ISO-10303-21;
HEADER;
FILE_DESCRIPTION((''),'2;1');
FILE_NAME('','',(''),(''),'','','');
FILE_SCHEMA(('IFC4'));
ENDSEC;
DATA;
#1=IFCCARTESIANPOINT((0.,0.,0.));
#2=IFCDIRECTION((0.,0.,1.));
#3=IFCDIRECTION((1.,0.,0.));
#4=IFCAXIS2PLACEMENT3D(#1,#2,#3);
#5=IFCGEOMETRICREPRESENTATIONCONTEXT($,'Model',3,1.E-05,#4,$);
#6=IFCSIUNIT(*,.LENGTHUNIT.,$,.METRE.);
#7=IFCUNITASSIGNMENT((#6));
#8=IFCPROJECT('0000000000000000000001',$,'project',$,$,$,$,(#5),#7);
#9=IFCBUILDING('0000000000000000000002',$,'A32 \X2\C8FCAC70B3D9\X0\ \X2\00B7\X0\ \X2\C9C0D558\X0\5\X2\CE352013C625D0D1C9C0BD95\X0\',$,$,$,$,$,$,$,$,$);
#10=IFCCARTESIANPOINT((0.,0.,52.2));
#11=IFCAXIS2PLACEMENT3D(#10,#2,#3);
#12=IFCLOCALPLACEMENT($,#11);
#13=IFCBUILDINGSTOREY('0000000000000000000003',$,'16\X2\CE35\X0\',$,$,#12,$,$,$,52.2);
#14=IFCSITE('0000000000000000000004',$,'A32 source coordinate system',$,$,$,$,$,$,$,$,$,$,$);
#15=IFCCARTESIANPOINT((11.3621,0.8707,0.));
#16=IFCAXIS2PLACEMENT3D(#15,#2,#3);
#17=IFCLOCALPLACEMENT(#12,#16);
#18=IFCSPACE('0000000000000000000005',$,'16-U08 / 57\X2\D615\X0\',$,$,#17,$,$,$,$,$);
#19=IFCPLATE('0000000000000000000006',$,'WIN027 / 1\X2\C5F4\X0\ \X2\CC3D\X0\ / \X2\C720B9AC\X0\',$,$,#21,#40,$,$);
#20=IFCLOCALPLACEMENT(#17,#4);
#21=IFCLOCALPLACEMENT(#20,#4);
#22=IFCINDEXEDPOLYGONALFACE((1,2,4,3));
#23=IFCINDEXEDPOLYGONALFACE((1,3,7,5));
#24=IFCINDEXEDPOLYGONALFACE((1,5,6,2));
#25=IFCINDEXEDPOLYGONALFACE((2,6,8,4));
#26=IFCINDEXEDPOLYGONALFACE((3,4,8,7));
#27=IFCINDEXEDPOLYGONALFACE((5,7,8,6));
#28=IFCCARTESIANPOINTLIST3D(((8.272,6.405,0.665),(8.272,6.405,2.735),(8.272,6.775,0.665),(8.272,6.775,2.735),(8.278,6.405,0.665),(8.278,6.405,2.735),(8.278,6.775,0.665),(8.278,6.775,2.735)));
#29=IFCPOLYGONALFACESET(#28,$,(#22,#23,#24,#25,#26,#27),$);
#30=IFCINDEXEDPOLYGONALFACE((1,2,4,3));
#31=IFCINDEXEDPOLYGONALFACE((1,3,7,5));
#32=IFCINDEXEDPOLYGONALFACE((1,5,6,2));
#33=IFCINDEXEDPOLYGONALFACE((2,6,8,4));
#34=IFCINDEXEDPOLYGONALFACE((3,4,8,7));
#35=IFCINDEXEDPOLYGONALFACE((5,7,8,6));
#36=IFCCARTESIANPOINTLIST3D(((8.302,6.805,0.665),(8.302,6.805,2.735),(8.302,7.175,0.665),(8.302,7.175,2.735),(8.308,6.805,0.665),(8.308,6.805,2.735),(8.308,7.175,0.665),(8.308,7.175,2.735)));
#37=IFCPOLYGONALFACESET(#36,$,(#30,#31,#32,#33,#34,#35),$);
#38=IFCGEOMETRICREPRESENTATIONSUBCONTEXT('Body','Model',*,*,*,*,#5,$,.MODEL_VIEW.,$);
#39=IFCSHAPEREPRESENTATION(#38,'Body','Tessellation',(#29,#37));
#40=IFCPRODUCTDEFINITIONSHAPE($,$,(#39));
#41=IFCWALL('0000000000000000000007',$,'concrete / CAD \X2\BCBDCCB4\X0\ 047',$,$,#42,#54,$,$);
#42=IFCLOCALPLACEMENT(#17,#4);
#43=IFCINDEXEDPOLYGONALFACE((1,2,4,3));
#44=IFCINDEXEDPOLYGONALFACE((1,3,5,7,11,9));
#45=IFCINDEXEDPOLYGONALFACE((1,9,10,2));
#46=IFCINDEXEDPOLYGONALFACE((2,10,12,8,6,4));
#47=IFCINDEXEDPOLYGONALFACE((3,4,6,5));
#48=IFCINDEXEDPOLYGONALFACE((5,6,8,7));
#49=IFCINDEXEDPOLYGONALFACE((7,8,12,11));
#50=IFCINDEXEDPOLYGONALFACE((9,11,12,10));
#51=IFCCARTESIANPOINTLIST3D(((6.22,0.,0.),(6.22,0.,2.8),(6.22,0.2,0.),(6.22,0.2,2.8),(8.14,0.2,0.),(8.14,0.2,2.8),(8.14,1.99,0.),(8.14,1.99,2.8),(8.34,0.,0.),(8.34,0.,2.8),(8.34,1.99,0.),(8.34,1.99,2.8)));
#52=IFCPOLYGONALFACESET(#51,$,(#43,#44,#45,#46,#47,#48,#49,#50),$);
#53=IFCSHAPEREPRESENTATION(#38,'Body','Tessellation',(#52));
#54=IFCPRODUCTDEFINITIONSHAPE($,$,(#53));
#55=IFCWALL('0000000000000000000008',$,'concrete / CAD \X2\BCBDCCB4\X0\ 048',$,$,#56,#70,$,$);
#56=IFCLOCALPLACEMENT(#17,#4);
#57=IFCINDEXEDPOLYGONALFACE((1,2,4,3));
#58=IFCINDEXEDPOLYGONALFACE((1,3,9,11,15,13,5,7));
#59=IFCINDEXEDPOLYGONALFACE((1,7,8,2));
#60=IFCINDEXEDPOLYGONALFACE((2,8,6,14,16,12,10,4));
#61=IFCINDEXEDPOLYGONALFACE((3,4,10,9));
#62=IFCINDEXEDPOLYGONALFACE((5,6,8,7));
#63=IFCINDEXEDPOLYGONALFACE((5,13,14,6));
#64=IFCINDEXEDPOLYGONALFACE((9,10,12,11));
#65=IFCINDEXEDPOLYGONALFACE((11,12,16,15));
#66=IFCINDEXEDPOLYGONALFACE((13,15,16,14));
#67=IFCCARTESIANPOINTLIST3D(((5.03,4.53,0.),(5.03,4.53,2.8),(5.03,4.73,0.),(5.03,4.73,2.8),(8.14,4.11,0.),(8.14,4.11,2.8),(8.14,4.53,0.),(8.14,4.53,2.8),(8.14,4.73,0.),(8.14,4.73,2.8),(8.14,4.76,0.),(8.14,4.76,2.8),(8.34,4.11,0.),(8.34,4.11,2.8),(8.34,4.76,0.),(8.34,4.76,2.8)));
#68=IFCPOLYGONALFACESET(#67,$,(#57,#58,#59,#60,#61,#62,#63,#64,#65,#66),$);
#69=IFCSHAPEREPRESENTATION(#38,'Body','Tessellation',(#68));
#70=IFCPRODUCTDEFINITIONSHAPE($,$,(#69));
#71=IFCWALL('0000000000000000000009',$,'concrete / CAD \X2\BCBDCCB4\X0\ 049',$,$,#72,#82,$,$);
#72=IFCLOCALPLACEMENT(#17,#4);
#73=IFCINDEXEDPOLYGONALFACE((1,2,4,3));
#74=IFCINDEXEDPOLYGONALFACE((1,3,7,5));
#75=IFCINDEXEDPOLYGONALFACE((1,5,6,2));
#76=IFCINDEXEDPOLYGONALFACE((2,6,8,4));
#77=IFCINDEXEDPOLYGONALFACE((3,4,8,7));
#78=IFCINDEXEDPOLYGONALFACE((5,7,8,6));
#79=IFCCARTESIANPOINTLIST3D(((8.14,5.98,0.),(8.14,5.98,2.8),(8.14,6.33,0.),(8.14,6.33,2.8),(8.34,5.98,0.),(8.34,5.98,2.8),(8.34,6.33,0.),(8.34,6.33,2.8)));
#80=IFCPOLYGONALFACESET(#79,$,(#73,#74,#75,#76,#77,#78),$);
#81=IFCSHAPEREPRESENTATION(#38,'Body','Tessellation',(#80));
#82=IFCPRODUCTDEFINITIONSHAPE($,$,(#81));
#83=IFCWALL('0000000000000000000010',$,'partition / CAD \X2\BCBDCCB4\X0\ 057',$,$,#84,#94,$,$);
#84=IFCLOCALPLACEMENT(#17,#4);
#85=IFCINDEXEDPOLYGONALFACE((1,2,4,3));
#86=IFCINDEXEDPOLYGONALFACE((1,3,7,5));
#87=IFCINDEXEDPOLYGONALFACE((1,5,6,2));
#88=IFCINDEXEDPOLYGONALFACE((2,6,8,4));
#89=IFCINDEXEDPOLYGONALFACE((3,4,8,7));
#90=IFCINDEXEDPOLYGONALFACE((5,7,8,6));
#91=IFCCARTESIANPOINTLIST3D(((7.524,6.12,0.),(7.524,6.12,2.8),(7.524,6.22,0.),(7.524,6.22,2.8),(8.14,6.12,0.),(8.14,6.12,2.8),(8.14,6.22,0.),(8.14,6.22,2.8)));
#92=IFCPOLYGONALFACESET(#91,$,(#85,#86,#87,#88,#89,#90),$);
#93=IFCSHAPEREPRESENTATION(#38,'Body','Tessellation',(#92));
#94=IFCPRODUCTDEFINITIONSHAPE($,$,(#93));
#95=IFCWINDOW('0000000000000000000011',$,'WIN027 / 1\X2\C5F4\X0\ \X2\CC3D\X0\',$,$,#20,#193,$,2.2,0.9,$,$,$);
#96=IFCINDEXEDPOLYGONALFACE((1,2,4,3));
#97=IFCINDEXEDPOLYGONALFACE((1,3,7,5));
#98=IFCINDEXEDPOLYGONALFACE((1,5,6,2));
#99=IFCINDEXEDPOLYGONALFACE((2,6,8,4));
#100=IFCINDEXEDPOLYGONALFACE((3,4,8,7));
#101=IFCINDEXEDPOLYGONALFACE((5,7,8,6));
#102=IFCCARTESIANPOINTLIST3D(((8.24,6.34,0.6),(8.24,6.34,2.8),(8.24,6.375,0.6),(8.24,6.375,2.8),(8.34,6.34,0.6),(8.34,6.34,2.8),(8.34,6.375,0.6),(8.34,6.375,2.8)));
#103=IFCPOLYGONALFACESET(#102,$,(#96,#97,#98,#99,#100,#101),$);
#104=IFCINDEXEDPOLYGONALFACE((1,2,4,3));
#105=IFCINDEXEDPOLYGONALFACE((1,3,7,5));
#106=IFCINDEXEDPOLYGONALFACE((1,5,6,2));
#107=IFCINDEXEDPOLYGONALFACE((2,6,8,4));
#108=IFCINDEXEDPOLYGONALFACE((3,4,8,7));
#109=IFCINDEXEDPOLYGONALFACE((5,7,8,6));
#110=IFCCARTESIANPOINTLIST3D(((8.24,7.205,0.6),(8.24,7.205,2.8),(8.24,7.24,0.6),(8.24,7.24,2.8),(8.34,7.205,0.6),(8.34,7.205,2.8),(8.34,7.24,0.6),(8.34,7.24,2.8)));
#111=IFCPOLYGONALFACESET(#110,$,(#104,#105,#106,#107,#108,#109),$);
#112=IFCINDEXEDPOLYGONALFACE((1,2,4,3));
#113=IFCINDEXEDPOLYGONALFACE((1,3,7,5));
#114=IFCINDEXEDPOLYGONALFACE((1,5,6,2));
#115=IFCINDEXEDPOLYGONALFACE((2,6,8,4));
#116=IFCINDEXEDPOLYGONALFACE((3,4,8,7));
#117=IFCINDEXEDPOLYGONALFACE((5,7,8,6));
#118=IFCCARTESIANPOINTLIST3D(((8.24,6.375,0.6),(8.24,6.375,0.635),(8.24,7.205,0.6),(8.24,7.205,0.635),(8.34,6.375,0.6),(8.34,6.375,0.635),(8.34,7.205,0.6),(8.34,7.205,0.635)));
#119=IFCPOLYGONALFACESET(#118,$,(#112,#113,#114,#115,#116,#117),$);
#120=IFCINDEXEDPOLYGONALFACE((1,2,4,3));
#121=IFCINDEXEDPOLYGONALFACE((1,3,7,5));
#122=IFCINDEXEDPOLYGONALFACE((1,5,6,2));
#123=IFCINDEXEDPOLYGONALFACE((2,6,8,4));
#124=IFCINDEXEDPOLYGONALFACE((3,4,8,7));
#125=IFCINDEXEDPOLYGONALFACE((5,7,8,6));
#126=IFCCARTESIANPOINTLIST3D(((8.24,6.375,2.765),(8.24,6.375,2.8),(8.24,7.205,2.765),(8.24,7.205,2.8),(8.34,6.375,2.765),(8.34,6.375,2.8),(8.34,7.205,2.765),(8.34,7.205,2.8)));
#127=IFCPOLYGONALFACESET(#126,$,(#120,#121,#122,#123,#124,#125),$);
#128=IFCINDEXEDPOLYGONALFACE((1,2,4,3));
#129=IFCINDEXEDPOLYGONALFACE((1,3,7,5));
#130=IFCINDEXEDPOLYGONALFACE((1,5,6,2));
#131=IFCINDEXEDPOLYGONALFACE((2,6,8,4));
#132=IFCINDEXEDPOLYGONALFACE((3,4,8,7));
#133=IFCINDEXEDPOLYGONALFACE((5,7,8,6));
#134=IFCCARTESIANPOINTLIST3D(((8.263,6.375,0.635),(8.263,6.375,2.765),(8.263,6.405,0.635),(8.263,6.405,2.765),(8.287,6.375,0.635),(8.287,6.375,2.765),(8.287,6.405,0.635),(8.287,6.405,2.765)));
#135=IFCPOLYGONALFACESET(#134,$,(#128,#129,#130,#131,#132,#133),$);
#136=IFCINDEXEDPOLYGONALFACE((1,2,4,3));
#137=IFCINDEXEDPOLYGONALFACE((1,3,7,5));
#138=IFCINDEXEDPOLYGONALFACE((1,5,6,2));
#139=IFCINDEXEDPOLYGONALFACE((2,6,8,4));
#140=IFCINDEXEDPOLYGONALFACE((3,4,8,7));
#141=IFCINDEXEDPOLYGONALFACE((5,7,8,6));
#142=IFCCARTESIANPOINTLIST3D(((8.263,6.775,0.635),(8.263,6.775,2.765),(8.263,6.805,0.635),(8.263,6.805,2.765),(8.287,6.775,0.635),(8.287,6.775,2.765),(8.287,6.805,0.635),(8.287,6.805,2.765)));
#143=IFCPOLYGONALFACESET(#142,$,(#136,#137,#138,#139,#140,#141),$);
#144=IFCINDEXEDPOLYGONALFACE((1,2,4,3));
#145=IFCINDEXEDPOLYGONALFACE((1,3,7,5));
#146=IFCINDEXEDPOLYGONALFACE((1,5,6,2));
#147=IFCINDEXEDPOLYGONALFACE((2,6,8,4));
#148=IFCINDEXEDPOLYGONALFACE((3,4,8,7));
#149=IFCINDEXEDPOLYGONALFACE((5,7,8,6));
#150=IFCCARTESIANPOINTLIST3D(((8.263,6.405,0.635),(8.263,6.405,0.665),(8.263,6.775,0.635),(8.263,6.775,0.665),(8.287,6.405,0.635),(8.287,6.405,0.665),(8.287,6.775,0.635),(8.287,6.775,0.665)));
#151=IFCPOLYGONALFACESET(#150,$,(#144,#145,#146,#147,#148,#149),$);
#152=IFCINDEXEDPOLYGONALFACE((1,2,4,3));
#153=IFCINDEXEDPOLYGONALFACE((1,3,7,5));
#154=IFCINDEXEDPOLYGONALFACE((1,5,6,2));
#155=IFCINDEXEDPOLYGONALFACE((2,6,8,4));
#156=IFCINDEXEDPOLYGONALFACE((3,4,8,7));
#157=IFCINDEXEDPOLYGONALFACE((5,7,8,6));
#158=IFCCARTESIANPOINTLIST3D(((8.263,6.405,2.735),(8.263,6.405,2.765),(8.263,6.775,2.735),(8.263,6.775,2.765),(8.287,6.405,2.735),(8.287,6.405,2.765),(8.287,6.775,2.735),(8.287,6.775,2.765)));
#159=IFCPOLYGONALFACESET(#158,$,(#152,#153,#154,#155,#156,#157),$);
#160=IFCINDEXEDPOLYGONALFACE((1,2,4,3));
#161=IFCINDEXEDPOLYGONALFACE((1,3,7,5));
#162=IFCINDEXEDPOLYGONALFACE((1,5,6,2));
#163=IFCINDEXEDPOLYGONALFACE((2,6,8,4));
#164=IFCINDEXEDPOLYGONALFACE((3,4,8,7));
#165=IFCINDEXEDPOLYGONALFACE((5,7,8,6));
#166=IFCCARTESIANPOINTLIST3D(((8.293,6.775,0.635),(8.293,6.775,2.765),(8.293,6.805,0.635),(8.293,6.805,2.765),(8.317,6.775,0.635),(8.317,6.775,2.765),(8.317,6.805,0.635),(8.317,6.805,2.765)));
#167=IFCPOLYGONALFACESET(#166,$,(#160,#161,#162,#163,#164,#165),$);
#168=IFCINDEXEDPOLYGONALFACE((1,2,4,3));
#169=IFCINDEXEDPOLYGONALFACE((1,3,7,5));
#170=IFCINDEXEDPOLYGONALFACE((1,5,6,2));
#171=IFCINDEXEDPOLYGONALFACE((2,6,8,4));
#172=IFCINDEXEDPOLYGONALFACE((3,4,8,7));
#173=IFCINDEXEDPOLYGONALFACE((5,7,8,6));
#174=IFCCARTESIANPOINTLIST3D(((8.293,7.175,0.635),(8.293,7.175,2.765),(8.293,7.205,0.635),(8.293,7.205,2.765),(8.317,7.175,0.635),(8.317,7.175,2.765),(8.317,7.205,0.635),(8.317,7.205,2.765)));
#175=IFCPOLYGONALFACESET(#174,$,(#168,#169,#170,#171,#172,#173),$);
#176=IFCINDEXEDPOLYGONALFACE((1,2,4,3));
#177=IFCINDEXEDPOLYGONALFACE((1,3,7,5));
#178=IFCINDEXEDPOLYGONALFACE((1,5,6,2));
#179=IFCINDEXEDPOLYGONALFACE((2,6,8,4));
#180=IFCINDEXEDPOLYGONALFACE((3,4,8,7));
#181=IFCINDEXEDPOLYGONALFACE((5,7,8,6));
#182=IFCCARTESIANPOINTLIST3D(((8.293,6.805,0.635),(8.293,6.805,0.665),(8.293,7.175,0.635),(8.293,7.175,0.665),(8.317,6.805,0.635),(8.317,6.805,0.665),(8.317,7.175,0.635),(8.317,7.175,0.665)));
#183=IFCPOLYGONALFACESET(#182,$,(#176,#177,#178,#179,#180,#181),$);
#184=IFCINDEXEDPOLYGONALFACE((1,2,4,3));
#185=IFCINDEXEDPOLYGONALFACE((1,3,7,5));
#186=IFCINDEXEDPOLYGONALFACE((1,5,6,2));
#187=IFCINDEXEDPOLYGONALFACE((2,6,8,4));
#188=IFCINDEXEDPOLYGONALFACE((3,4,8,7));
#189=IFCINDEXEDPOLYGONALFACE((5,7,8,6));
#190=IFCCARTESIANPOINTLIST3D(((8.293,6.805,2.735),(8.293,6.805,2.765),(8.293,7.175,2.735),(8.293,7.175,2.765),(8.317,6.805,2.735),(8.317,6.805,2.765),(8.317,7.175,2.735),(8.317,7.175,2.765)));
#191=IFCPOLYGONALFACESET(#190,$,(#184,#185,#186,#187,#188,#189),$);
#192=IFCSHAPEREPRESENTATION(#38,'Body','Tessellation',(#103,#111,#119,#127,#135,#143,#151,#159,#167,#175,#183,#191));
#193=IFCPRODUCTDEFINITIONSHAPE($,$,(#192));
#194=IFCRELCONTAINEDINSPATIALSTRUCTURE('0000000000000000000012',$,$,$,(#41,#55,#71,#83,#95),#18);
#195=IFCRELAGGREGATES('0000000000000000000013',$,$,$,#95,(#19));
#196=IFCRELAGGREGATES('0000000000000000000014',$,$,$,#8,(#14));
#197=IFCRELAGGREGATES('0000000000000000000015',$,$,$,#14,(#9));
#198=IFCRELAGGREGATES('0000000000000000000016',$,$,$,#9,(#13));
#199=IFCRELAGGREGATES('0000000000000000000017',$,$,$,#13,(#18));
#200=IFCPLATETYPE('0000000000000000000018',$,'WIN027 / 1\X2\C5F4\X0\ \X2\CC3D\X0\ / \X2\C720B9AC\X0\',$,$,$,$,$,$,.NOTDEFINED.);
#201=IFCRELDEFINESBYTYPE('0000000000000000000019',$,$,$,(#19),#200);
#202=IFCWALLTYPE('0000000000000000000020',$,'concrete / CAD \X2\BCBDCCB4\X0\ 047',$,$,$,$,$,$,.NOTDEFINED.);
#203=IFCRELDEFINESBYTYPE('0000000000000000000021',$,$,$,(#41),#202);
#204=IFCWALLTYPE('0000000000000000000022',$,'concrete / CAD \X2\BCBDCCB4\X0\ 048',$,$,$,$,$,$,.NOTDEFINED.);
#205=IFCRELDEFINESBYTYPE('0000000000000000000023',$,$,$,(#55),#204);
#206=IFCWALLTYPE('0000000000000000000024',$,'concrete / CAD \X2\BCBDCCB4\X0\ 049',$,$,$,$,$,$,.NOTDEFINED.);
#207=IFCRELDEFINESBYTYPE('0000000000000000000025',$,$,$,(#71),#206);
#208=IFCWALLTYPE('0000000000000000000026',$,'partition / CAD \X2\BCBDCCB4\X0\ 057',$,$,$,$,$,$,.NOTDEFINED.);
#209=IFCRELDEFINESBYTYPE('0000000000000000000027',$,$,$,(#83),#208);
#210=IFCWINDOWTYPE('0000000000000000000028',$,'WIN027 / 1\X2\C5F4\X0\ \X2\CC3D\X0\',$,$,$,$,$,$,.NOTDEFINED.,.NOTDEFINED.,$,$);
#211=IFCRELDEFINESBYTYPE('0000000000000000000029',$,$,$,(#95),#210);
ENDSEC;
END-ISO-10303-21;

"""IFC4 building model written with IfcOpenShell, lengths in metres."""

from ifc_helpers import new_model, si_unit, frame, origin, origin_with_axes, place, context, subcontext, project, spatial, polyline, outline, extrude, source, transform, mapped, type_object, type_shapes, element, aggregate, save


model = new_model("IFC4")

# Units and contexts
model_context = context("Model", 3, precision=1e-05, world=origin_with_axes())
body_context = subcontext(model_context, "Body", "Model", "MODEL_VIEW")
ifc_project = project(units=[si_unit("LENGTHUNIT", "METRE")], contexts=[model_context])

# Plate
storey_placement = place(None, frame((0.0, 0.0, 52.2), z_axis=(0.0, 0.0, 1.0), x_axis=(1.0, 0.0, 0.0)))
space_placement = place(storey_placement, frame((11.3621, 0.8707, 0.0), z_axis=(0.0, 0.0, 1.0), x_axis=(1.0, 0.0, 0.0)))
plate_type_1 = type_object("IfcPlateType", Name="WIN027 / 1열 창 / 유리", PredefinedType="NOTDEFINED")
shared_shape_1 = source(origin(), body_context, "Body", "SweptSolid", [
    extrude(outline(polyline([(8.272, 6.405), (8.272, 6.775), (8.278, 6.775), (8.278, 6.405), (8.272, 6.405)])), frame((0.0, 0.0, 0.665)), (0.0, 0.0, 1.0), 2.07),
    extrude(outline(polyline([(8.302, 6.805), (8.302, 7.175), (8.308, 7.175), (8.308, 6.805), (8.302, 6.805)])), frame((0.0, 0.0, 0.665)), (0.0, 0.0, 1.0), 2.07),
])
type_shapes(plate_type_1, [shared_shape_1])
window_1_placement = place(space_placement, origin_with_axes())
plate_1_placement = place(window_1_placement, origin_with_axes())
plate_1 = element("IfcPlate", 1, at=plate_1_placement, type_object=plate_type_1, Name="WIN027 / 1열 창 / 유리", context=body_context, shape_type="MappedRepresentation", body=[
    mapped(shared_shape_1, transform((0.0, 0.0, 0.0), scale=1.0)),
])

# Site, building, storey, space
site = spatial("IfcSite", under=ifc_project, Name="A32 source coordinate system")
building = spatial("IfcBuilding", under=site, Name="A32 주거동 · 지하5층–옥탑지붕")
storey = spatial("IfcBuildingStorey", under=building, at=storey_placement, Name="16층", Elevation=52.2)
space = spatial("IfcSpace", under=storey, at=space_placement, Name="16-U08 / 57형")

# Walls
wall_type_1 = type_object("IfcWallType", Name="concrete / CAD 벽체 047", PredefinedType="NOTDEFINED")
shared_shape_2 = source(origin(), body_context, "Body", "SweptSolid", [
    extrude(outline(polyline([(8.14, 1.99), (8.34, 1.99), (8.34, 0.0), (6.22, 0.0), (6.22, 0.2), (8.14, 0.2), (8.14, 1.99)])), origin(), (0.0, 0.0, 1.0), 2.8),
])
type_shapes(wall_type_1, [shared_shape_2])
wall_1_placement = place(space_placement, origin_with_axes())
element("IfcWall", 2, at=wall_1_placement, inside=space, type_object=wall_type_1, Name="concrete / CAD 벽체 047", context=body_context, shape_type="MappedRepresentation", body=[
    mapped(shared_shape_2, transform((0.0, 0.0, 0.0), scale=1.0)),
])
wall_type_2 = type_object("IfcWallType", Name="concrete / CAD 벽체 048", PredefinedType="NOTDEFINED")
shared_shape_3 = source(origin(), body_context, "Body", "SweptSolid", [
    extrude(outline(polyline([(8.14, 4.53), (5.03, 4.53), (5.03, 4.73), (8.14, 4.73), (8.14, 4.76), (8.34, 4.76), (8.34, 4.11), (8.14, 4.11), (8.14, 4.53)])), origin(), (0.0, 0.0, 1.0), 2.8),
])
type_shapes(wall_type_2, [shared_shape_3])
wall_2_placement = place(space_placement, origin_with_axes())
element("IfcWall", 3, at=wall_2_placement, inside=space, type_object=wall_type_2, Name="concrete / CAD 벽체 048", context=body_context, shape_type="MappedRepresentation", body=[
    mapped(shared_shape_3, transform((0.0, 0.0, 0.0), scale=1.0)),
])
wall_type_3 = type_object("IfcWallType", Name="concrete / CAD 벽체 049", PredefinedType="NOTDEFINED")
shared_shape_4 = source(origin(), body_context, "Body", "SweptSolid", [
    extrude(outline(polyline([(8.34, 6.33), (8.34, 5.98), (8.14, 5.98), (8.14, 6.33), (8.34, 6.33)])), origin(), (0.0, 0.0, 1.0), 2.8),
])
type_shapes(wall_type_3, [shared_shape_4])
wall_3_placement = place(space_placement, origin_with_axes())
element("IfcWall", 4, at=wall_3_placement, inside=space, type_object=wall_type_3, Name="concrete / CAD 벽체 049", context=body_context, shape_type="MappedRepresentation", body=[
    mapped(shared_shape_4, transform((0.0, 0.0, 0.0), scale=1.0)),
])
wall_type_4 = type_object("IfcWallType", Name="partition / CAD 벽체 057", PredefinedType="NOTDEFINED")
shared_shape_5 = source(origin(), body_context, "Body", "SweptSolid", [
    extrude(outline(polyline([(7.524, 6.22), (8.14, 6.22), (8.14, 6.12), (7.524, 6.12), (7.524, 6.22)])), origin(), (0.0, 0.0, 1.0), 2.8),
])
type_shapes(wall_type_4, [shared_shape_5])
wall_4_placement = place(space_placement, origin_with_axes())
element("IfcWall", 5, at=wall_4_placement, inside=space, type_object=wall_type_4, Name="partition / CAD 벽체 057", context=body_context, shape_type="MappedRepresentation", body=[
    mapped(shared_shape_5, transform((0.0, 0.0, 0.0), scale=1.0)),
])

# Window
window_type_1 = type_object("IfcWindowType", Name="WIN027 / 1열 창", PartitioningType="NOTDEFINED", PredefinedType="NOTDEFINED")
shared_shape_6 = source(origin(), body_context, "Body", "SweptSolid", [
    extrude(outline(polyline([(8.24, 6.34), (8.24, 6.375), (8.34, 6.375), (8.34, 6.34), (8.24, 6.34)])), frame((0.0, 0.0, 0.6)), (0.0, 0.0, 1.0), 2.2),
    extrude(outline(polyline([(8.24, 7.205), (8.24, 7.24), (8.34, 7.24), (8.34, 7.205), (8.24, 7.205)])), frame((0.0, 0.0, 0.6)), (0.0, 0.0, 1.0), 2.2),
    extrude(outline(polyline([(8.24, 6.375), (8.24, 7.205), (8.34, 7.205), (8.34, 6.375), (8.24, 6.375)])), frame((0.0, 0.0, 0.6)), (0.0, 0.0, 1.0), 0.035),
    extrude(outline(polyline([(8.24, 6.375), (8.24, 7.205), (8.34, 7.205), (8.34, 6.375), (8.24, 6.375)])), frame((0.0, 0.0, 2.765)), (0.0, 0.0, 1.0), 0.035),
    extrude(outline(polyline([(8.263, 6.375), (8.263, 6.405), (8.287, 6.405), (8.287, 6.375), (8.263, 6.375)])), frame((0.0, 0.0, 0.635)), (0.0, 0.0, 1.0), 2.13),
    extrude(outline(polyline([(8.263, 6.775), (8.263, 6.805), (8.287, 6.805), (8.287, 6.775), (8.263, 6.775)])), frame((0.0, 0.0, 0.635)), (0.0, 0.0, 1.0), 2.13),
    extrude(outline(polyline([(8.263, 6.405), (8.263, 6.775), (8.287, 6.775), (8.287, 6.405), (8.263, 6.405)])), frame((0.0, 0.0, 0.635)), (0.0, 0.0, 1.0), 0.03),
    extrude(outline(polyline([(8.263, 6.405), (8.263, 6.775), (8.287, 6.775), (8.287, 6.405), (8.263, 6.405)])), frame((0.0, 0.0, 2.735)), (0.0, 0.0, 1.0), 0.03),
    extrude(outline(polyline([(8.293, 6.775), (8.293, 6.805), (8.317, 6.805), (8.317, 6.775), (8.293, 6.775)])), frame((0.0, 0.0, 0.635)), (0.0, 0.0, 1.0), 2.13),
    extrude(outline(polyline([(8.293, 7.175), (8.293, 7.205), (8.317, 7.205), (8.317, 7.175), (8.293, 7.175)])), frame((0.0, 0.0, 0.635)), (0.0, 0.0, 1.0), 2.13),
    extrude(outline(polyline([(8.293, 6.805), (8.293, 7.175), (8.317, 7.175), (8.317, 6.805), (8.293, 6.805)])), frame((0.0, 0.0, 0.635)), (0.0, 0.0, 1.0), 0.03),
    extrude(outline(polyline([(8.293, 6.805), (8.293, 7.175), (8.317, 7.175), (8.317, 6.805), (8.293, 6.805)])), frame((0.0, 0.0, 2.735)), (0.0, 0.0, 1.0), 0.03),
])
type_shapes(window_type_1, [shared_shape_6])
window_1 = element("IfcWindow", 6, at=window_1_placement, inside=space, type_object=window_type_1, Name="WIN027 / 1열 창", OverallHeight=2.2, OverallWidth=0.9, context=body_context, shape_type="MappedRepresentation", body=[
    mapped(shared_shape_6, transform((0.0, 0.0, 0.0), scale=1.0)),
])
aggregate(window_1, [plate_1])

save(model, "model.ifc")
